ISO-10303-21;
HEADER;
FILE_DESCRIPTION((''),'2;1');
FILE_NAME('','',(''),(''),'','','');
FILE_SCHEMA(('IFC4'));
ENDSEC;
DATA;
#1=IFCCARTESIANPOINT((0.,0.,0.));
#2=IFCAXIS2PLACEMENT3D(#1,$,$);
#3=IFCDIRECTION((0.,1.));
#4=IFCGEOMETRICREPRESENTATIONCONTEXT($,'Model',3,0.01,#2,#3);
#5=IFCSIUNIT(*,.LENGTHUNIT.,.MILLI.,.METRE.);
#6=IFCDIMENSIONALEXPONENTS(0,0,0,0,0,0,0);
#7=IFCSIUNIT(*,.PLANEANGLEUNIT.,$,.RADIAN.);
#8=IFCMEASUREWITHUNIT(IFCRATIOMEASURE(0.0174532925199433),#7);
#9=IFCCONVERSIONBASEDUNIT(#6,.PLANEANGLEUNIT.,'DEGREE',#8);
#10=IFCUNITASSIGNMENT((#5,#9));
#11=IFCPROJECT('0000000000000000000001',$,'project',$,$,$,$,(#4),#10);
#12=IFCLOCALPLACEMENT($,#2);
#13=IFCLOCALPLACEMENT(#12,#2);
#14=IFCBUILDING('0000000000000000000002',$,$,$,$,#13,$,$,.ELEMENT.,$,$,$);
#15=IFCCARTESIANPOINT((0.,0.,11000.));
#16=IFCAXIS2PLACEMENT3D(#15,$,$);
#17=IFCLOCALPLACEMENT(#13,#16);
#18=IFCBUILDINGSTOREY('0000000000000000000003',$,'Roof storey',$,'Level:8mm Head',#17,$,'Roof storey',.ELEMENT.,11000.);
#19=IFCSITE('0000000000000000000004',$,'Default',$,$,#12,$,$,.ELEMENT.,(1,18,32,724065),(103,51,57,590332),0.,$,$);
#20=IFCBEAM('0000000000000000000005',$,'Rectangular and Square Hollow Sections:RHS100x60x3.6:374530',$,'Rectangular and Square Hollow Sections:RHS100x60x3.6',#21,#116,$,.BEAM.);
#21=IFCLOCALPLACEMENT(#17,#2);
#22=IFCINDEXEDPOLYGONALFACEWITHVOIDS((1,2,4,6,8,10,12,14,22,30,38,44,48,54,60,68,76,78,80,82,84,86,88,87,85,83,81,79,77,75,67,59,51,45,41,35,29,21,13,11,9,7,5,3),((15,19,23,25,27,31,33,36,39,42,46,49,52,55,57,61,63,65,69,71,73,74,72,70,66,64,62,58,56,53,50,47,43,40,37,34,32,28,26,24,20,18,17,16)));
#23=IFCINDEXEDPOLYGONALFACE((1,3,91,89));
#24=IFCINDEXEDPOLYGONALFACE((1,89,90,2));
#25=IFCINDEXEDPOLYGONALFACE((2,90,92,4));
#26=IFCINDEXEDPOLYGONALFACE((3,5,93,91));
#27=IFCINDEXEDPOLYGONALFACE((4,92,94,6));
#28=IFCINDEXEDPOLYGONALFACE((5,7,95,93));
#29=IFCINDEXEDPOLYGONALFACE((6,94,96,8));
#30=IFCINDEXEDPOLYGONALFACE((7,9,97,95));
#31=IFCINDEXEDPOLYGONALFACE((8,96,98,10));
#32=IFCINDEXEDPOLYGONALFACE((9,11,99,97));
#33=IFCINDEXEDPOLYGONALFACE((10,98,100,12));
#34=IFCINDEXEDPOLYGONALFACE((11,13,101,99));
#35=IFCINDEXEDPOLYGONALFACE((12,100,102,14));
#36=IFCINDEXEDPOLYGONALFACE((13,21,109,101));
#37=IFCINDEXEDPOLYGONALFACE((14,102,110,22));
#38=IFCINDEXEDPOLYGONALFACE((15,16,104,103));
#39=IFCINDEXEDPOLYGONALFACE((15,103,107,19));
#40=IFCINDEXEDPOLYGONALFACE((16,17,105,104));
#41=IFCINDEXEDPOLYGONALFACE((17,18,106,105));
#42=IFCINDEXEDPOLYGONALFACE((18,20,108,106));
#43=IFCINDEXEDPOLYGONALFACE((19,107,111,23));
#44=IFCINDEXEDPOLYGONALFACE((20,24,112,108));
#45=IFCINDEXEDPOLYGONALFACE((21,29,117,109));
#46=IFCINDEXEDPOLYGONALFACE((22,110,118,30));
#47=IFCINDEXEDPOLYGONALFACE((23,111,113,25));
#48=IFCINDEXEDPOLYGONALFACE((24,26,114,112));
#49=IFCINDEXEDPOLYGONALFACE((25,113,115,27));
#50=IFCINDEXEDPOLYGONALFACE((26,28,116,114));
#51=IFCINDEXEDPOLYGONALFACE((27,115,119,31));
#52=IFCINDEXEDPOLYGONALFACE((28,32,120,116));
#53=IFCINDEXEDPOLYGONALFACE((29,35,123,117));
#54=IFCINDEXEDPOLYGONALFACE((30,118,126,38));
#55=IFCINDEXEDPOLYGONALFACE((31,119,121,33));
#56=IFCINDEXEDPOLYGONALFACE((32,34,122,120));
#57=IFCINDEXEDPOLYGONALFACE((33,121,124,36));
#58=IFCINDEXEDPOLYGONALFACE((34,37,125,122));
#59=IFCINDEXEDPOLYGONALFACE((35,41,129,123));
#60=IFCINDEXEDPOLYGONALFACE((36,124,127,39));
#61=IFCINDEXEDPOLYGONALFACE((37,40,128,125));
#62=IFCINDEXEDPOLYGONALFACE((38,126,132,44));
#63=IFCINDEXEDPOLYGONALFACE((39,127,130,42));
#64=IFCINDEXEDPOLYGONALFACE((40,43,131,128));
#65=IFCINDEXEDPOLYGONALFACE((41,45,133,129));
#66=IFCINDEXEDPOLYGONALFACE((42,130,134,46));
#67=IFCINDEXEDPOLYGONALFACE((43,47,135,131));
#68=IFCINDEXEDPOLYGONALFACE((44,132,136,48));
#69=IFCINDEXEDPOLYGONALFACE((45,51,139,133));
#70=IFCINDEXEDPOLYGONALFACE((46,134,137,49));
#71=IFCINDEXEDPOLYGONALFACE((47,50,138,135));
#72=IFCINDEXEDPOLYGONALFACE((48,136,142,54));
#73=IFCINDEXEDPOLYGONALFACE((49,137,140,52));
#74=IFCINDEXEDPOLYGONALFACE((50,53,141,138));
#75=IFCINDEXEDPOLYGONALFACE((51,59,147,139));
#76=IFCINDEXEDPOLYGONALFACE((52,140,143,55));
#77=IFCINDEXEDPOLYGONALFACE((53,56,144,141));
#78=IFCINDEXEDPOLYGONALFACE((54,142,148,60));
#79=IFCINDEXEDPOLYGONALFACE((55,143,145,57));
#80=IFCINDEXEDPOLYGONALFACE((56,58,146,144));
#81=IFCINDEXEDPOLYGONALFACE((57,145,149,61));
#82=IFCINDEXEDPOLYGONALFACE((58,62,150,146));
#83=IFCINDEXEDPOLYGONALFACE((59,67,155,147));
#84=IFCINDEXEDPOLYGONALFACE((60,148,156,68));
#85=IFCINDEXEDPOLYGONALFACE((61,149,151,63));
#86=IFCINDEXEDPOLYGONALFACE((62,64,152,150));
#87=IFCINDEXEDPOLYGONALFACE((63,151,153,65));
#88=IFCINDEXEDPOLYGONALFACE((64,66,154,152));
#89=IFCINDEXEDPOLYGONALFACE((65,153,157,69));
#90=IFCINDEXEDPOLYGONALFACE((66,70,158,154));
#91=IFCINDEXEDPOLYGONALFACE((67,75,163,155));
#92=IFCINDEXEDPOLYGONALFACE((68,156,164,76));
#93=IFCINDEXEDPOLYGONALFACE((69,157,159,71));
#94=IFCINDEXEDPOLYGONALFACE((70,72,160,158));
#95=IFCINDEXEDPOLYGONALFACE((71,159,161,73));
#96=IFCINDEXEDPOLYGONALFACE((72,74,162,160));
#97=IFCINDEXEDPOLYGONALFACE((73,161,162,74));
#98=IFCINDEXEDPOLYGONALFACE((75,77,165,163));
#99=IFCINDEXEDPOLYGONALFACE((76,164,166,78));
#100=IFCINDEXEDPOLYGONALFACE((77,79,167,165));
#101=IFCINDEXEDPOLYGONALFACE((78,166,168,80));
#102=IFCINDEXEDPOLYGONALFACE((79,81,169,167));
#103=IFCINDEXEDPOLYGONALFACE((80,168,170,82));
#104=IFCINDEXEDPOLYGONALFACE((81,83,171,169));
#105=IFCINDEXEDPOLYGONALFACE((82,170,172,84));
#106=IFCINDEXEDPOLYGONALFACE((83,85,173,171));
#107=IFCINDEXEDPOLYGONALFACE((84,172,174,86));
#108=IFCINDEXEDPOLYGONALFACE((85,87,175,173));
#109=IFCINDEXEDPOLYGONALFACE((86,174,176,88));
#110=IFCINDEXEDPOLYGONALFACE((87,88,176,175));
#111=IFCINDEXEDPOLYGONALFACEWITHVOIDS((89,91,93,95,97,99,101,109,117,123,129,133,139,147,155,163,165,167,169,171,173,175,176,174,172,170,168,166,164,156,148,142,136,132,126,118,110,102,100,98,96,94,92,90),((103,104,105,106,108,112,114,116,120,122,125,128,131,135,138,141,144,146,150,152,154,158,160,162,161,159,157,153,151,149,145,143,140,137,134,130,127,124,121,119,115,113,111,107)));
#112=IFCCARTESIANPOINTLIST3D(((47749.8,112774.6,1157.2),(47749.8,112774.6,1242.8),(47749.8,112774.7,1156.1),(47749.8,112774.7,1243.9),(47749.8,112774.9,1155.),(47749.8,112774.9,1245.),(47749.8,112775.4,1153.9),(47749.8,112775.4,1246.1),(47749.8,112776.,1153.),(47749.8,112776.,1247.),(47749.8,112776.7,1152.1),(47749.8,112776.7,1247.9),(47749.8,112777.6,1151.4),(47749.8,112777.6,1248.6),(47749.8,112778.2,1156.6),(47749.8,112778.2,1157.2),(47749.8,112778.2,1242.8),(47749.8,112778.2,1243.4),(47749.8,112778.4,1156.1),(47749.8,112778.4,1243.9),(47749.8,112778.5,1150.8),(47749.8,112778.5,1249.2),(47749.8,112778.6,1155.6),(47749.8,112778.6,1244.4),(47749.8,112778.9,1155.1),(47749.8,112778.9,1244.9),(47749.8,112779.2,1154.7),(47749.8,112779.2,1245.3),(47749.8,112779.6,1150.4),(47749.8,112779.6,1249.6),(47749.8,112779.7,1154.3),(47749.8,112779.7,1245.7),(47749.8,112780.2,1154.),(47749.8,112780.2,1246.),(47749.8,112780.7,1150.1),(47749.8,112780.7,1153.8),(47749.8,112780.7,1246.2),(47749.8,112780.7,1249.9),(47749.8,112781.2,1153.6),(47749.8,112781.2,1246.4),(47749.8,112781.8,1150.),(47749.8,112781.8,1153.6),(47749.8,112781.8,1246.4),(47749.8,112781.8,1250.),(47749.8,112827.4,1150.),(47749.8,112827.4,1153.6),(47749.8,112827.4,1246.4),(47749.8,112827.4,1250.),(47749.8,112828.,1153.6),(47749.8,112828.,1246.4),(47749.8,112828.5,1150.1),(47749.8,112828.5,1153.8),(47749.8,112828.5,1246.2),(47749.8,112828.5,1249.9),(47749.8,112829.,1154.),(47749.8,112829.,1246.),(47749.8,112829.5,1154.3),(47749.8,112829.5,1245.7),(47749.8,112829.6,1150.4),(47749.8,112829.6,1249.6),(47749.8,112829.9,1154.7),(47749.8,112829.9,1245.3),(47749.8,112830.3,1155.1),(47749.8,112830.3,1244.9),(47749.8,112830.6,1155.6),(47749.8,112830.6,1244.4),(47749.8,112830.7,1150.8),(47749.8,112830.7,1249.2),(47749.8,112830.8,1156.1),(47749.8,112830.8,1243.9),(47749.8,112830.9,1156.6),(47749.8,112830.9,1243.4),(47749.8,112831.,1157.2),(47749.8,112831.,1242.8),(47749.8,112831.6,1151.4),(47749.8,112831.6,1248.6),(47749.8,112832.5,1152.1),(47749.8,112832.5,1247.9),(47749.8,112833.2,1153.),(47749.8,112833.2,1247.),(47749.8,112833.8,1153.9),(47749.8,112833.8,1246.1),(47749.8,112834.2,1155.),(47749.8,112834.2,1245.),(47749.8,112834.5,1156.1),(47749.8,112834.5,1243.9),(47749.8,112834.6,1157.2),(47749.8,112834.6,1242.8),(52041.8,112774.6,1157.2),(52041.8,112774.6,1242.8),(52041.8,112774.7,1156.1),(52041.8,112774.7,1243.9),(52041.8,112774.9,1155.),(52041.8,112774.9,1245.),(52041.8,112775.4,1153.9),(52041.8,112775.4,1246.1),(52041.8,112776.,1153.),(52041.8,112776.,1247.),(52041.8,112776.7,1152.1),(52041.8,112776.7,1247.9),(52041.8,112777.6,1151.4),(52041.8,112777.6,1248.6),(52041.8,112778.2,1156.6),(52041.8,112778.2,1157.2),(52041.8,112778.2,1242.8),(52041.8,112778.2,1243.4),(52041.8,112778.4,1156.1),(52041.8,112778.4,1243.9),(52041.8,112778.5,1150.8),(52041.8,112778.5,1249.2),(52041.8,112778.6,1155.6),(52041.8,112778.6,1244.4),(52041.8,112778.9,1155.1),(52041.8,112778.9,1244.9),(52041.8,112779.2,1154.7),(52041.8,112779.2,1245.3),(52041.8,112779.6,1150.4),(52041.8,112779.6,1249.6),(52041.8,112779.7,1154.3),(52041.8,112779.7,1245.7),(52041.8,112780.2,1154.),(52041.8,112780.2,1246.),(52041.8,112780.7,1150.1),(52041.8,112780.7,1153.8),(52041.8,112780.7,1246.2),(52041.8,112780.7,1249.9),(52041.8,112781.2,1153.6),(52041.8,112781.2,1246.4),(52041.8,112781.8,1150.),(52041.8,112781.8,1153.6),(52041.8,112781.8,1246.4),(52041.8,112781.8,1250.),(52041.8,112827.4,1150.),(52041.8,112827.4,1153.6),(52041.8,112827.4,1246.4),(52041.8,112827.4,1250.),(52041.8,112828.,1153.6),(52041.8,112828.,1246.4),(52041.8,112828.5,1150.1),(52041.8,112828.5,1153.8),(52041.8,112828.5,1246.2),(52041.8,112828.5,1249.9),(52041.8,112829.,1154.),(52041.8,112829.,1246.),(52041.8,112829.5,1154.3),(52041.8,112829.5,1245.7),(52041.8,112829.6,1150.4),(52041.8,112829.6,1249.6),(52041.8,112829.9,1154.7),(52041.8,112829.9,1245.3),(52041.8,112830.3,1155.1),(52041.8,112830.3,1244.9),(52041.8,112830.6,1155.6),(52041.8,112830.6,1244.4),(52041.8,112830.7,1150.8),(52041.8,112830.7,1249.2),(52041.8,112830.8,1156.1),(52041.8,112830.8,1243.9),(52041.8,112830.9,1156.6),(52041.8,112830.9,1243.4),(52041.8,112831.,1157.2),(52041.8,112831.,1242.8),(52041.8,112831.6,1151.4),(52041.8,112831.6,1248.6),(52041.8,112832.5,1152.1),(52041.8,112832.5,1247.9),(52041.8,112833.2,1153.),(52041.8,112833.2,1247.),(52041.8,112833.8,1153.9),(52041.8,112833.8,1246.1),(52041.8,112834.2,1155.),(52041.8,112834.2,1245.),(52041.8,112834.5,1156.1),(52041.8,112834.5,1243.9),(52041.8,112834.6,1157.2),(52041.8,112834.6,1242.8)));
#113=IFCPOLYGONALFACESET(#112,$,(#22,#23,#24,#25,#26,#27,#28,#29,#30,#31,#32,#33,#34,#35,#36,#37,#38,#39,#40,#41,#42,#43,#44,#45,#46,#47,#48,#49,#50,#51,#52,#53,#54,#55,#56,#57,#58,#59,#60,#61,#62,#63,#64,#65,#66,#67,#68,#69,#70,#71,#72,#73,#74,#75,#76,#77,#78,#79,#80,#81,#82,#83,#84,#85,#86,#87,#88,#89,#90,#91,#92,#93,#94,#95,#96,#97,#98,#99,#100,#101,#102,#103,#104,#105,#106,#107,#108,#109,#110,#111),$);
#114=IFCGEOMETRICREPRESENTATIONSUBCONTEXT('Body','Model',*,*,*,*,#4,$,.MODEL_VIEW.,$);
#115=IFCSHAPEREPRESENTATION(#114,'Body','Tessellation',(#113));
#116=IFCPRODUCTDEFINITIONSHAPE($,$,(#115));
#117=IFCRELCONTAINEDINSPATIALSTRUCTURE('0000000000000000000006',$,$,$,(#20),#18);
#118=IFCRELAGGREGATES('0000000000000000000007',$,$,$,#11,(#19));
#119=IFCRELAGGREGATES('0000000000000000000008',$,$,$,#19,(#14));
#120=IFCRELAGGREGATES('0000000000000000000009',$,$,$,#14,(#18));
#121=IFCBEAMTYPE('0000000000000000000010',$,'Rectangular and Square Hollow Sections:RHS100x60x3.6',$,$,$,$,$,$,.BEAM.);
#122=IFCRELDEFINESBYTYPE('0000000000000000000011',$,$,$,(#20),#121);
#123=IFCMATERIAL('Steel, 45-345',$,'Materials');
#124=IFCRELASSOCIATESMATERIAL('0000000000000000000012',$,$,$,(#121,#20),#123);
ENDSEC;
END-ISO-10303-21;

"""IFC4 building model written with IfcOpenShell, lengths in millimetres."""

from ifc_helpers import new_model, entity, si_unit, converted_unit, direction, frame, origin, place, context, subcontext, project, spatial, indexed_curve, outline, extrude, source, transform, mapped, material, type_object, type_shapes, element, save


model = new_model("IFC4")

# Units and contexts
model_context = context("Model", 3, precision=0.01, world=origin(), true_north=direction((0.0, 1.0)))
body_context = subcontext(model_context, "Body", "Model", "MODEL_VIEW")
ifc_project = project(units=[si_unit("LENGTHUNIT", "METRE", prefix="MILLI"), converted_unit("PLANEANGLEUNIT", "DEGREE", entity("IfcRatioMeasure", 0.0174532925199433), si_unit("PLANEANGLEUNIT", "RADIAN"), dimensions=[0, 0, 0, 0, 0, 0, 0])], contexts=[model_context])

# Site, building, storey
site_placement = place(None, origin())
site = spatial("IfcSite", under=ifc_project, at=site_placement, Name="Default", CompositionType="ELEMENT", RefLatitude=(1, 18, 32, 724065), RefLongitude=(103, 51, 57, 590332), RefElevation=0.0)
building_placement = place(site_placement, origin())
building = spatial("IfcBuilding", under=site, at=building_placement, CompositionType="ELEMENT")
storey_placement = place(building_placement, frame((0.0, 0.0, 11000.0)))
storey = spatial("IfcBuildingStorey", under=building, at=storey_placement, Name="Roof storey", ObjectType="Level:8mm Head", LongName="Roof storey", CompositionType="ELEMENT", Elevation=11000.0)

# Shared definitions
ifc_material = material(Name="Steel, 45-345", Category="Materials")

# Beam
beam_type_1 = type_object("IfcBeamType", Name="Rectangular and Square Hollow Sections:RHS100x60x3.6", PredefinedType="BEAM", material=ifc_material)
shared_shape_1 = source(origin(), body_context, "Body", "SweptSolid", [
    extrude(outline(indexed_curve([(-30.0, -42.8), (-29.9, -43.9), (-29.6, -45.0), (-29.2, -46.1), (-28.6, -47.0), (-27.9, -47.9), (-27.0, -48.6), (-26.1, -49.2), (-25.0, -49.6), (-23.9, -49.9), (-22.8, -50.0), (22.8, -50.0), (23.9, -49.9), (25.0, -49.6), (26.1, -49.2), (27.0, -48.6), (27.9, -47.9), (28.6, -47.0), (29.2, -46.1), (29.6, -45.0), (29.9, -43.9), (30.0, -42.8), (30.0, 42.8), (29.9, 43.9), (29.6, 45.0), (29.2, 46.1), (28.6, 47.0), (27.9, 47.9), (27.0, 48.6), (26.1, 49.2), (25.0, 49.6), (23.9, 49.9), (22.8, 50.0), (-22.8, 50.0), (-23.9, 49.9), (-25.0, 49.6), (-26.1, 49.2), (-27.0, 48.6), (-27.9, 47.9), (-28.6, 47.0), (-29.2, 46.1), (-29.6, 45.0), (-29.9, 43.9), (-30.0, 42.8), (-30.0, -42.8)], self_intersect=False), holes=[indexed_curve([(22.8, -46.4), (-22.8, -46.4), (-23.4, -46.4), (-23.9, -46.2), (-24.4, -46.0), (-24.9, -45.7), (-25.3, -45.3), (-25.7, -44.9), (-26.0, -44.4), (-26.2, -43.9), (-26.4, -43.4), (-26.4, -42.8), (-26.4, 42.8), (-26.4, 43.4), (-26.2, 43.9), (-26.0, 44.4), (-25.7, 44.9), (-25.3, 45.3), (-24.9, 45.7), (-24.4, 46.0), (-23.9, 46.2), (-23.4, 46.4), (-22.8, 46.4), (22.8, 46.4), (23.4, 46.4), (23.9, 46.2), (24.4, 46.0), (24.9, 45.7), (25.3, 45.3), (25.7, 44.9), (26.0, 44.4), (26.2, 43.9), (26.4, 43.4), (26.4, 42.8), (26.4, -42.8), (26.4, -43.4), (26.2, -43.9), (26.0, -44.4), (25.7, -44.9), (25.3, -45.3), (24.9, -45.7), (24.4, -46.0), (23.9, -46.2), (23.4, -46.4), (22.8, -46.4)], self_intersect=False)]), frame((-2139.5, 0.0, 0.0), z_axis=(1.0, 0.0, 0.0), x_axis=(0.0, -1.0, 0.0)), (0.0, 0.0, 1.0), 4292.0),
])
type_shapes(beam_type_1, [shared_shape_1])
for number, where, name in (
    (1, (49889.3, 112804.6, 1200.0), "Rectangular and Square Hollow Sections:RHS100x60x3.6:374530"),
):
    element("IfcBeam", number, at=place(storey_placement, frame(where)), inside=storey, type_object=beam_type_1, material=ifc_material, Name=name, ObjectType="Rectangular and Square Hollow Sections:RHS100x60x3.6", PredefinedType="BEAM", context=body_context, shape_type="MappedRepresentation", body=[
        mapped(shared_shape_1, transform((0.0, 0.0, 0.0), scale=1.0)),
    ])

save(model, "model.ifc")
